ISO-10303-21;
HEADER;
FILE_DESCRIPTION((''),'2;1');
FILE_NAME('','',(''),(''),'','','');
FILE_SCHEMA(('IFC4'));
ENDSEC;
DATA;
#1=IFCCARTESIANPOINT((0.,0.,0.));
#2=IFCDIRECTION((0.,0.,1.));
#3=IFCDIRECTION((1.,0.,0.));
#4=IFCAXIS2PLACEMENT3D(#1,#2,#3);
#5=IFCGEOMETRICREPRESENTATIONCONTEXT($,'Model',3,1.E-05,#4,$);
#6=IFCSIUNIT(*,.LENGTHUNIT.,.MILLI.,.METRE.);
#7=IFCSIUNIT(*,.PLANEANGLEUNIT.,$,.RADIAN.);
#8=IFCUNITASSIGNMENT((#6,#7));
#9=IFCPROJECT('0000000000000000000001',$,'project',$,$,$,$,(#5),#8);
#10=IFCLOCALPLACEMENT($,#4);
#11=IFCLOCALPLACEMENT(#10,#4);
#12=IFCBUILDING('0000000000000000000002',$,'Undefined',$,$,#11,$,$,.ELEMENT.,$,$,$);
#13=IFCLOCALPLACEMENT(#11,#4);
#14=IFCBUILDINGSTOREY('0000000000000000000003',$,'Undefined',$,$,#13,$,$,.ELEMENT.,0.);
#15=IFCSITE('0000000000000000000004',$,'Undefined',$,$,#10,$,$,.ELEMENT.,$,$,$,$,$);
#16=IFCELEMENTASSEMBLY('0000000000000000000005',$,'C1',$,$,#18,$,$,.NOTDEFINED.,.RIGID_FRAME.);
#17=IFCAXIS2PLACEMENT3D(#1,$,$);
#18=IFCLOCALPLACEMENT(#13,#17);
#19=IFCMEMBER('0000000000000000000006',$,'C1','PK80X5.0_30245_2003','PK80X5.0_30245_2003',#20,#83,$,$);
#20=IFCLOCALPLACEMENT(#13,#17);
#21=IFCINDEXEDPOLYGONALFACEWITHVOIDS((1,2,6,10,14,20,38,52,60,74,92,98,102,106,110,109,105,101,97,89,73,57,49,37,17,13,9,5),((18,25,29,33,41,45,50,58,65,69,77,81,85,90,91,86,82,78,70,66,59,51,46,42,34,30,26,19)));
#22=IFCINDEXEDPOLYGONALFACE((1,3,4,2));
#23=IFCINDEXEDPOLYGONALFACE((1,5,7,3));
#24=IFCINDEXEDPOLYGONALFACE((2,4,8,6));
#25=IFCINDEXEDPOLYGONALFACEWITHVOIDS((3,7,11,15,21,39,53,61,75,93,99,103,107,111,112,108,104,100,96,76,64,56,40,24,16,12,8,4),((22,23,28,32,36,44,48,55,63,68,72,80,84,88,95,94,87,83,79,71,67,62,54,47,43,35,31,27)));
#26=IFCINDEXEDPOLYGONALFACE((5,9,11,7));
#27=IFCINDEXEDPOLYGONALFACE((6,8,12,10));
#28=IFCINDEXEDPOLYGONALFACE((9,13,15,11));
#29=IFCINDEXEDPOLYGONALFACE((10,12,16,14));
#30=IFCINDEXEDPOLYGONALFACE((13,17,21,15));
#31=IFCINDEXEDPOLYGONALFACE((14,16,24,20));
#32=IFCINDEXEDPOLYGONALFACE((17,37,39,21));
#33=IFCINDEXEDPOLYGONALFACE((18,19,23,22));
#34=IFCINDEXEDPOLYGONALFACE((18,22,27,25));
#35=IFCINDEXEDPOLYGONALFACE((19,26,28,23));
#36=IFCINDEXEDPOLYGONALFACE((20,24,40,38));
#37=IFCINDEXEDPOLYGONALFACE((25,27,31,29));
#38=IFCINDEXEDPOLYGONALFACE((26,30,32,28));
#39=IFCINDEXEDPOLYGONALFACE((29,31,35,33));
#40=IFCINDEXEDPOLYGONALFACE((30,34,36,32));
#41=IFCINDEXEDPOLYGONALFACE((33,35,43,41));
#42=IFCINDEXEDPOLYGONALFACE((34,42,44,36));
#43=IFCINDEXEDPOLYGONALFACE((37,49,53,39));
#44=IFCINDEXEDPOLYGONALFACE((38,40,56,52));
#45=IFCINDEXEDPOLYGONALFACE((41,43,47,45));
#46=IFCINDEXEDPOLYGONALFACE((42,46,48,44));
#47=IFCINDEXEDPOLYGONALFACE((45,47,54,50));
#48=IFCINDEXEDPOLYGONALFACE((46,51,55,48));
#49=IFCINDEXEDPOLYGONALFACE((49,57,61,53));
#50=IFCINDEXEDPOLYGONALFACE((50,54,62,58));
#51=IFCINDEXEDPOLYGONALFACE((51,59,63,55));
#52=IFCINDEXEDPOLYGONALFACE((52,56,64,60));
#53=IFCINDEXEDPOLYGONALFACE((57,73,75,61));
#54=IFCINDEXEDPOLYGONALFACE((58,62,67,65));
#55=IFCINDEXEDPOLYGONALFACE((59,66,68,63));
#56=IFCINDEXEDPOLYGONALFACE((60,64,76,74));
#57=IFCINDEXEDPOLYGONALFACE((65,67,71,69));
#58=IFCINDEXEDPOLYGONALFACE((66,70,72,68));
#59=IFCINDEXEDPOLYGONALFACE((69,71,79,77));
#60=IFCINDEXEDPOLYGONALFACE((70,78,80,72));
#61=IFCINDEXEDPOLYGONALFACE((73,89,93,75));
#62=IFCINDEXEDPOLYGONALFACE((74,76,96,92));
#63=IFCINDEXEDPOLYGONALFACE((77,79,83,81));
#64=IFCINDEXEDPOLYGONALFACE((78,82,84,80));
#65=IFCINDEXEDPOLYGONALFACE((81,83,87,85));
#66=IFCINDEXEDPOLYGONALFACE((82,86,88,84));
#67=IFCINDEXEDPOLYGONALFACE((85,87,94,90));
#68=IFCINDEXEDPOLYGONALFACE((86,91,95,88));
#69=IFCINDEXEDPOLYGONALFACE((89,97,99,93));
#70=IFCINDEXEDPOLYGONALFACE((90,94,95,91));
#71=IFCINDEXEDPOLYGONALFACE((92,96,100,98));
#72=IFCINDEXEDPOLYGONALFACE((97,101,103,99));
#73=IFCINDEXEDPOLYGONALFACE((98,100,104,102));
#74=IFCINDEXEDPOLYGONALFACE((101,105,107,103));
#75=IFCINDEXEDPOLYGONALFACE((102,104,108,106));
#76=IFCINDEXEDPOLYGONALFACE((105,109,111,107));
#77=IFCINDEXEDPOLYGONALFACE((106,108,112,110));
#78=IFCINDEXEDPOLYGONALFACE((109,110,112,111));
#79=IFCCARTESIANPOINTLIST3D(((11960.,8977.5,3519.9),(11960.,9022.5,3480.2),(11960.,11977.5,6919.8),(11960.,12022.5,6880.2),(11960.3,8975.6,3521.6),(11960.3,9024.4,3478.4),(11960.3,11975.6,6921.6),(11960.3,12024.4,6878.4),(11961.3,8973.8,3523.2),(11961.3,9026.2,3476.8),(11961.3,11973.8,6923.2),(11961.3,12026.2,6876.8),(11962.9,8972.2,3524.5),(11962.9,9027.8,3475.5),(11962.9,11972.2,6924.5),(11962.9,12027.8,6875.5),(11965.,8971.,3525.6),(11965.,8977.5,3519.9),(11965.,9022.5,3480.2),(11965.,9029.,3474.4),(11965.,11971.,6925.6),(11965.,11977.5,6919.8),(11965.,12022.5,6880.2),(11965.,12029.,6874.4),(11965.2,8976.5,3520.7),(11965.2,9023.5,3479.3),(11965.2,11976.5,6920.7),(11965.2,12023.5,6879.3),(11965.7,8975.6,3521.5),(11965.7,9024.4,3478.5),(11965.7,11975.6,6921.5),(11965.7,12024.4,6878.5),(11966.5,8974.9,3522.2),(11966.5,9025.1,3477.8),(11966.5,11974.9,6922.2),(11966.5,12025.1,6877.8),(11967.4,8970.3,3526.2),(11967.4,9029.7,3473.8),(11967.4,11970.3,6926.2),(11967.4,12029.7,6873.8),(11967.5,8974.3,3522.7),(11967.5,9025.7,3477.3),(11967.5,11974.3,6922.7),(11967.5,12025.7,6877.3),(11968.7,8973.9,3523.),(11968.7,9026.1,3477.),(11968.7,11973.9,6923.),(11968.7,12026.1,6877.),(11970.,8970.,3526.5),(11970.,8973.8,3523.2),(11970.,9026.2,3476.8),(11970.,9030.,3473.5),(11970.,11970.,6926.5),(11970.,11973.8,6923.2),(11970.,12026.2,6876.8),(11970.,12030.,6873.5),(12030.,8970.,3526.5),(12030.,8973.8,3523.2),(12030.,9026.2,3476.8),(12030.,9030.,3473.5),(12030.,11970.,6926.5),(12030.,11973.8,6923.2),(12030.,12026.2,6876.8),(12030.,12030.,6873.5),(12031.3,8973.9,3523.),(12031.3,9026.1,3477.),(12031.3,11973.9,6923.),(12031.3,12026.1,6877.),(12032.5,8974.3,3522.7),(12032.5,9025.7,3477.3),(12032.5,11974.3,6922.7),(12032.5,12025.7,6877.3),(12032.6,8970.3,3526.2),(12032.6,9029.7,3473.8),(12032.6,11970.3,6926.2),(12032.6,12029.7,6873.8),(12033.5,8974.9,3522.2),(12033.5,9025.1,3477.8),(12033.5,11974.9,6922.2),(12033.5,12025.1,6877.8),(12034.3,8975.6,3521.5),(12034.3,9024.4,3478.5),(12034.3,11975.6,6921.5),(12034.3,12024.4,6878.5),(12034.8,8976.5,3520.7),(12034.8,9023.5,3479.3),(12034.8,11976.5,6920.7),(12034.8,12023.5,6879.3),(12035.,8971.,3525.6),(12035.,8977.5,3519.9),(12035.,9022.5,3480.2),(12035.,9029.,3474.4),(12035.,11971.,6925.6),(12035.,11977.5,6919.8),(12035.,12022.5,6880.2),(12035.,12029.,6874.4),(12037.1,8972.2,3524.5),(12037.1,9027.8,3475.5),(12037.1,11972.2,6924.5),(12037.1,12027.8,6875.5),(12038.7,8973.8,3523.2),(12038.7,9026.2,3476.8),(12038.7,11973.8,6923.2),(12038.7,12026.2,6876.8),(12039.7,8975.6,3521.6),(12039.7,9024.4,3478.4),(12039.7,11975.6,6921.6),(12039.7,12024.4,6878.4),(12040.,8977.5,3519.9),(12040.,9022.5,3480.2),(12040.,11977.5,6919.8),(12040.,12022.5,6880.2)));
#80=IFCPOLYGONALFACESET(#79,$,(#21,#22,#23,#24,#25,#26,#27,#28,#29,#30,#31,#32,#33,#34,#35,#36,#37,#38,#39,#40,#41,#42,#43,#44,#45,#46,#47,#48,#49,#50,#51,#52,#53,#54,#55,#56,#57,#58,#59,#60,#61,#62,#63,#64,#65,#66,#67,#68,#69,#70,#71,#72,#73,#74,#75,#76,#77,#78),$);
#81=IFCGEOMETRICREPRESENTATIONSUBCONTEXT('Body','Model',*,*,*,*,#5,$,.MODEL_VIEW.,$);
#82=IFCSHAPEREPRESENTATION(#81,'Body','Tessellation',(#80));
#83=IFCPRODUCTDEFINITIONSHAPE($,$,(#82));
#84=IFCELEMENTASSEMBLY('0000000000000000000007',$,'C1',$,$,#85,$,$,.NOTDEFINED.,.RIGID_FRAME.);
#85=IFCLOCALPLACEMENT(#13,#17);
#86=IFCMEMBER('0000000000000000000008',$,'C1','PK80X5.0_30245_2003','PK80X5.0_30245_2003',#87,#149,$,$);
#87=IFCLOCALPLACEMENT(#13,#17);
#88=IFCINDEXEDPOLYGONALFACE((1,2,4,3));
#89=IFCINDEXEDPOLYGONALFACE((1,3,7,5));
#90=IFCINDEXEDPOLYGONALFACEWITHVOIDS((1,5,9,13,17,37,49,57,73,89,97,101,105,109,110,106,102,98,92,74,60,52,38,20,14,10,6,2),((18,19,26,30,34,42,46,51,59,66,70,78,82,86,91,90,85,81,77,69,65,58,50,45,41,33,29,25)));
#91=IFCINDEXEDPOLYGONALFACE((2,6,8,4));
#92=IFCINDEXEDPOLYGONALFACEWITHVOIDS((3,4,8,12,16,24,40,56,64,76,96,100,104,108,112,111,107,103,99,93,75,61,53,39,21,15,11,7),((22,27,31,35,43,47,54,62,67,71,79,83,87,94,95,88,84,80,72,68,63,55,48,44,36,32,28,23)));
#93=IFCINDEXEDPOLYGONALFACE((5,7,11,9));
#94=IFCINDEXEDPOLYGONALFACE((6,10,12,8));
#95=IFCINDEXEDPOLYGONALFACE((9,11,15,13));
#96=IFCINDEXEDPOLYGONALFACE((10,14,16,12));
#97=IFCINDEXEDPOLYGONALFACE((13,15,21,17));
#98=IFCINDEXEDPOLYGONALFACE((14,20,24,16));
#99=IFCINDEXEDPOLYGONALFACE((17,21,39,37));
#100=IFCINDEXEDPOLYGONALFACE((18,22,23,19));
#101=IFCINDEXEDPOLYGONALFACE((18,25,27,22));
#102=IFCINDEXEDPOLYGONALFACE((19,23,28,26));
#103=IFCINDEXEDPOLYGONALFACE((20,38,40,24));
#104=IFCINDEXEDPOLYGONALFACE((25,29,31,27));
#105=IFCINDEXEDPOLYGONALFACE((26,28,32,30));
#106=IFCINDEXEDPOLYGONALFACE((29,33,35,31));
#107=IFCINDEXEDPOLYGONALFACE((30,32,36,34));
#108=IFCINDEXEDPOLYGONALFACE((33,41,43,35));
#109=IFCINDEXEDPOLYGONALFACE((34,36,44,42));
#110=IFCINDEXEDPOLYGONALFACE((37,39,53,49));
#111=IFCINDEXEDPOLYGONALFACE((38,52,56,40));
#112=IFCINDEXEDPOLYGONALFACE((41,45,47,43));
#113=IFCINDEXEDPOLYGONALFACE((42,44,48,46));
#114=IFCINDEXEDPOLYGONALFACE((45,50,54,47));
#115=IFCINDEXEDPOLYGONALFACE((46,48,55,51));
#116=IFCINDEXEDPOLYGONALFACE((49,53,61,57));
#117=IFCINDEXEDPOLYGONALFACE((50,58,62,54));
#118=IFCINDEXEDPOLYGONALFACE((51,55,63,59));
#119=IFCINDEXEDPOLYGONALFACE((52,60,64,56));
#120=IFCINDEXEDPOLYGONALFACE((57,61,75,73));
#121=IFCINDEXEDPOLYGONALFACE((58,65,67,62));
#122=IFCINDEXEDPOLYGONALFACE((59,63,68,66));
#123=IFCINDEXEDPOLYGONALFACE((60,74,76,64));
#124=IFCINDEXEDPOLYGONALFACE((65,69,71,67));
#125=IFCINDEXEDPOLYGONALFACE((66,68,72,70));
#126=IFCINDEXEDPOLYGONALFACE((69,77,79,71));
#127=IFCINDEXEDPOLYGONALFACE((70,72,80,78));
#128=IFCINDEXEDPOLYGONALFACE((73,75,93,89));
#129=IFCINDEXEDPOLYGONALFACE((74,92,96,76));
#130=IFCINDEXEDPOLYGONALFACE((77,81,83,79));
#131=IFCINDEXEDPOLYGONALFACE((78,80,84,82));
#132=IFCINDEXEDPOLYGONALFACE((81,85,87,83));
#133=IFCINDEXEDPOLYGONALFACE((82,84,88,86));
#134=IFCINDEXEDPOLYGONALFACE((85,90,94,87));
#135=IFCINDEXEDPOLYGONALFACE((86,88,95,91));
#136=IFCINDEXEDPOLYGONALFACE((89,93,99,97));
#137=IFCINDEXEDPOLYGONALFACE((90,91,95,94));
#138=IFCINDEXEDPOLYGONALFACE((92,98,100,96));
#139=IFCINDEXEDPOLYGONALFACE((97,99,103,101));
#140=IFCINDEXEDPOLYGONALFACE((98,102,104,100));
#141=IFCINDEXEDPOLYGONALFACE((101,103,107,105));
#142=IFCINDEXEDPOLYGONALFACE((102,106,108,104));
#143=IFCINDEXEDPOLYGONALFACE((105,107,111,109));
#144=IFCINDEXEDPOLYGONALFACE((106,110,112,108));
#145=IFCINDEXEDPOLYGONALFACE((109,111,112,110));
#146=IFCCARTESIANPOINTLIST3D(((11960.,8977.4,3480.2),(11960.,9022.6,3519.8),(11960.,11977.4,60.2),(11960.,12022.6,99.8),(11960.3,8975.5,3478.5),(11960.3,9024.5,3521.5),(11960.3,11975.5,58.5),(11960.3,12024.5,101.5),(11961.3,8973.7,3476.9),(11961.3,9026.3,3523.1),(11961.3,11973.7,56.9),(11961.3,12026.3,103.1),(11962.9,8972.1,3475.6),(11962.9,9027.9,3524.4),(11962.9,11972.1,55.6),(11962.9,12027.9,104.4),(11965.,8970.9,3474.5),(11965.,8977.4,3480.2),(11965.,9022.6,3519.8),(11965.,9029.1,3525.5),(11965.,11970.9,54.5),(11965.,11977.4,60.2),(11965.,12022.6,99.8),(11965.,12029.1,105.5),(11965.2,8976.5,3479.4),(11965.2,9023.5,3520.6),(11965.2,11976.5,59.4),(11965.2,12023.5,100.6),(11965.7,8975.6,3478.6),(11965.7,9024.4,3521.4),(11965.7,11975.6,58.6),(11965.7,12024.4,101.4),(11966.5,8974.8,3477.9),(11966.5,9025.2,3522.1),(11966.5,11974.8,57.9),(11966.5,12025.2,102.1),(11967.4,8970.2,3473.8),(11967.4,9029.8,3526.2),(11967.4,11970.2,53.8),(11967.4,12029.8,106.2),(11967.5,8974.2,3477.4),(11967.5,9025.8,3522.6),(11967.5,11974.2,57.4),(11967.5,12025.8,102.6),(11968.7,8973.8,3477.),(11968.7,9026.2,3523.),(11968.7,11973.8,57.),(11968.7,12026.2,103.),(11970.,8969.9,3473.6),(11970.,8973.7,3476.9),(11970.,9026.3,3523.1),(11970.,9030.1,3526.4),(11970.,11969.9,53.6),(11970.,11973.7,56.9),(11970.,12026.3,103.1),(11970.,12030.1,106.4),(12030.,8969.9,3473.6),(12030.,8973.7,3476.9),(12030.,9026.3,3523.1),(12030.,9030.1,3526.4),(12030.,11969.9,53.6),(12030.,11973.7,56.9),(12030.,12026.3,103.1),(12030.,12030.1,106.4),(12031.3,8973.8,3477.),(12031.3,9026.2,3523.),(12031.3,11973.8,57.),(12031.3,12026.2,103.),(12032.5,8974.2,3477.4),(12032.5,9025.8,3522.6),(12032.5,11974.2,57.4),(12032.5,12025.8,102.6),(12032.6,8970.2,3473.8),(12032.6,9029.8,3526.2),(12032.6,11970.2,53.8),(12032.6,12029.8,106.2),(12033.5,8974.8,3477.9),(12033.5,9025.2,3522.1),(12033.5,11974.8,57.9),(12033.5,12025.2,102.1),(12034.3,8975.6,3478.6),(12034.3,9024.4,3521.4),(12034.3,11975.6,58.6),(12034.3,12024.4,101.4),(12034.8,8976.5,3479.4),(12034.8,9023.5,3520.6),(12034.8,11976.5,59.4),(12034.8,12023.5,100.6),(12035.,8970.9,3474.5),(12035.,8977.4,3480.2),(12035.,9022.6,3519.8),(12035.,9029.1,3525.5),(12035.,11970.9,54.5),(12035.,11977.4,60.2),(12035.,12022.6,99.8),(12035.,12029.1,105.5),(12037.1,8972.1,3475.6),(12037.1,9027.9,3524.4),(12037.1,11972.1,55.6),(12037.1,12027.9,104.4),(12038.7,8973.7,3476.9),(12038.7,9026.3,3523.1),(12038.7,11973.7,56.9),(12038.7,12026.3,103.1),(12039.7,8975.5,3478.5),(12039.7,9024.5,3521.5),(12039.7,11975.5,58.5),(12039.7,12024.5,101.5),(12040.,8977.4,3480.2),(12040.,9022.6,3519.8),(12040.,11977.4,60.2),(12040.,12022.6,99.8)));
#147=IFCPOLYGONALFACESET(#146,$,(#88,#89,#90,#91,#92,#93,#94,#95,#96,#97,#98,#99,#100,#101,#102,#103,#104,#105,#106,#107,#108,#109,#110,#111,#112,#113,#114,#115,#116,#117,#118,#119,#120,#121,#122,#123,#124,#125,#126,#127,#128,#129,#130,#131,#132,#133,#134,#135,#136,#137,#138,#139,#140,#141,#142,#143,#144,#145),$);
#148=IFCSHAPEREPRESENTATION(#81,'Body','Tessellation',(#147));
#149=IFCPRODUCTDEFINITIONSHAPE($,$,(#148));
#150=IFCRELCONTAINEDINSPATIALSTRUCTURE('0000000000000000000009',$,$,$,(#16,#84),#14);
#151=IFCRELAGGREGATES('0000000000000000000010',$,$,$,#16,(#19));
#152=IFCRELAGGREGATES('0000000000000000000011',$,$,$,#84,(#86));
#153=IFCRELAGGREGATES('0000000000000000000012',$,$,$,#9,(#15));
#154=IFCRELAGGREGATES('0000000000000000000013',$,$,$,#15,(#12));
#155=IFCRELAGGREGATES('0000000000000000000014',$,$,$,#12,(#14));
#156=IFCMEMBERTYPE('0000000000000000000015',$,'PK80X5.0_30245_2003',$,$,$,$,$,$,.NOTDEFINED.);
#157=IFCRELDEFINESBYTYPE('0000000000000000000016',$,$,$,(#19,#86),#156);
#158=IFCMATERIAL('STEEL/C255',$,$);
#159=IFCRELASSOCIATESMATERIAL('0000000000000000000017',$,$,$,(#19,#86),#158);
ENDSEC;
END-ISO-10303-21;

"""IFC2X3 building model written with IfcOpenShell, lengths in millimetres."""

from ifc_helpers import new_model, si_unit, frame, origin_with_axes, origin_2d_with_axis, place, context, subcontext, project, spatial, hollow_rectangle, extrude, material, type_object, element, aggregate, save


model = new_model("IFC2X3")

# Units and contexts
model_context = context("Model", 3, precision=1e-05, world=origin_with_axes())
body_context = subcontext(model_context, "Body", "Model", "MODEL_VIEW")
ifc_project = project(units=[si_unit("LENGTHUNIT", "METRE", prefix="MILLI"), si_unit("PLANEANGLEUNIT", "RADIAN")], contexts=[model_context])

# Site, building, storey
site_placement = place(None, origin_with_axes())
site = spatial("IfcSite", under=ifc_project, at=site_placement, Name="Undefined", CompositionType="ELEMENT")
building_placement = place(site_placement, origin_with_axes())
building = spatial("IfcBuilding", under=site, at=building_placement, Name="Undefined", CompositionType="ELEMENT")
storey_placement = place(building_placement, origin_with_axes())
storey = spatial("IfcBuildingStorey", under=building, at=storey_placement, Name="Undefined", CompositionType="ELEMENT", Elevation=0.0)

# Shared definitions
ifc_material_1 = material(Name="STEEL/C255")

# Element assemblies, members
member_type = type_object("IfcMemberType", Name="PK80X5.0_30245_2003", PredefinedType="NOTDEFINED")
assembly_1_placement = place(storey_placement, origin_with_axes())
assembly_1 = element("IfcElementAssembly", 1, at=assembly_1_placement, inside=storey, Name="C1", AssemblyPlace="NOTDEFINED", PredefinedType="RIGID_FRAME")
member_1_placement = place(assembly_1_placement, frame((12000.0, 9000.0, 3500.0), z_axis=(0.0, 0.749838, -0.661622), x_axis=(0.0, 0.661622, 0.749838)))
member_1 = element("IfcMember", 2, at=member_1_placement, type_object=member_type, material=ifc_material_1, Name="C1", Description="PK80X5.0_30245_2003", ObjectType="PK80X5.0_30245_2003", context=body_context, shape_type="SweptSolid", body=[
    extrude(hollow_rectangle(XDim=80.0, YDim=80.0, WallThickness=5.0, InnerFilletRadius=5.0, OuterFilletRadius=10.0, at=origin_2d_with_axis()), frame((4534.3, 0.0, 0.0), z_axis=(-1.0, 0.0, 0.0), x_axis=(0.0, -1.0, 0.0)), (0.0, 0.0, 1.0), 4534.3),
])
aggregate(assembly_1, [member_1])
assembly_2_placement = place(storey_placement, origin_with_axes())
assembly_2 = element("IfcElementAssembly", 3, at=assembly_2_placement, inside=storey, Name="C1", AssemblyPlace="NOTDEFINED", PredefinedType="RIGID_FRAME")
member_2_placement = place(assembly_2_placement, frame((12000.0, 12000.0, 80.0), z_axis=(0.0, -0.751759, -0.659438), x_axis=(0.0, -0.659438, 0.751759)))
member_2 = element("IfcMember", 4, at=member_2_placement, type_object=member_type, material=ifc_material_1, Name="C1", Description="PK80X5.0_30245_2003", ObjectType="PK80X5.0_30245_2003", context=body_context, shape_type="SweptSolid", body=[
    extrude(hollow_rectangle(XDim=80.0, YDim=80.0, WallThickness=5.0, InnerFilletRadius=5.0, OuterFilletRadius=10.0, at=origin_2d_with_axis()), frame((4549.3, 0.0, 0.0), z_axis=(-1.0, 0.0, 0.0), x_axis=(0.0, -1.0, 0.0)), (0.0, 0.0, 1.0), 4549.3),
])
aggregate(assembly_2, [member_2])

save(model, "model.ifc")
